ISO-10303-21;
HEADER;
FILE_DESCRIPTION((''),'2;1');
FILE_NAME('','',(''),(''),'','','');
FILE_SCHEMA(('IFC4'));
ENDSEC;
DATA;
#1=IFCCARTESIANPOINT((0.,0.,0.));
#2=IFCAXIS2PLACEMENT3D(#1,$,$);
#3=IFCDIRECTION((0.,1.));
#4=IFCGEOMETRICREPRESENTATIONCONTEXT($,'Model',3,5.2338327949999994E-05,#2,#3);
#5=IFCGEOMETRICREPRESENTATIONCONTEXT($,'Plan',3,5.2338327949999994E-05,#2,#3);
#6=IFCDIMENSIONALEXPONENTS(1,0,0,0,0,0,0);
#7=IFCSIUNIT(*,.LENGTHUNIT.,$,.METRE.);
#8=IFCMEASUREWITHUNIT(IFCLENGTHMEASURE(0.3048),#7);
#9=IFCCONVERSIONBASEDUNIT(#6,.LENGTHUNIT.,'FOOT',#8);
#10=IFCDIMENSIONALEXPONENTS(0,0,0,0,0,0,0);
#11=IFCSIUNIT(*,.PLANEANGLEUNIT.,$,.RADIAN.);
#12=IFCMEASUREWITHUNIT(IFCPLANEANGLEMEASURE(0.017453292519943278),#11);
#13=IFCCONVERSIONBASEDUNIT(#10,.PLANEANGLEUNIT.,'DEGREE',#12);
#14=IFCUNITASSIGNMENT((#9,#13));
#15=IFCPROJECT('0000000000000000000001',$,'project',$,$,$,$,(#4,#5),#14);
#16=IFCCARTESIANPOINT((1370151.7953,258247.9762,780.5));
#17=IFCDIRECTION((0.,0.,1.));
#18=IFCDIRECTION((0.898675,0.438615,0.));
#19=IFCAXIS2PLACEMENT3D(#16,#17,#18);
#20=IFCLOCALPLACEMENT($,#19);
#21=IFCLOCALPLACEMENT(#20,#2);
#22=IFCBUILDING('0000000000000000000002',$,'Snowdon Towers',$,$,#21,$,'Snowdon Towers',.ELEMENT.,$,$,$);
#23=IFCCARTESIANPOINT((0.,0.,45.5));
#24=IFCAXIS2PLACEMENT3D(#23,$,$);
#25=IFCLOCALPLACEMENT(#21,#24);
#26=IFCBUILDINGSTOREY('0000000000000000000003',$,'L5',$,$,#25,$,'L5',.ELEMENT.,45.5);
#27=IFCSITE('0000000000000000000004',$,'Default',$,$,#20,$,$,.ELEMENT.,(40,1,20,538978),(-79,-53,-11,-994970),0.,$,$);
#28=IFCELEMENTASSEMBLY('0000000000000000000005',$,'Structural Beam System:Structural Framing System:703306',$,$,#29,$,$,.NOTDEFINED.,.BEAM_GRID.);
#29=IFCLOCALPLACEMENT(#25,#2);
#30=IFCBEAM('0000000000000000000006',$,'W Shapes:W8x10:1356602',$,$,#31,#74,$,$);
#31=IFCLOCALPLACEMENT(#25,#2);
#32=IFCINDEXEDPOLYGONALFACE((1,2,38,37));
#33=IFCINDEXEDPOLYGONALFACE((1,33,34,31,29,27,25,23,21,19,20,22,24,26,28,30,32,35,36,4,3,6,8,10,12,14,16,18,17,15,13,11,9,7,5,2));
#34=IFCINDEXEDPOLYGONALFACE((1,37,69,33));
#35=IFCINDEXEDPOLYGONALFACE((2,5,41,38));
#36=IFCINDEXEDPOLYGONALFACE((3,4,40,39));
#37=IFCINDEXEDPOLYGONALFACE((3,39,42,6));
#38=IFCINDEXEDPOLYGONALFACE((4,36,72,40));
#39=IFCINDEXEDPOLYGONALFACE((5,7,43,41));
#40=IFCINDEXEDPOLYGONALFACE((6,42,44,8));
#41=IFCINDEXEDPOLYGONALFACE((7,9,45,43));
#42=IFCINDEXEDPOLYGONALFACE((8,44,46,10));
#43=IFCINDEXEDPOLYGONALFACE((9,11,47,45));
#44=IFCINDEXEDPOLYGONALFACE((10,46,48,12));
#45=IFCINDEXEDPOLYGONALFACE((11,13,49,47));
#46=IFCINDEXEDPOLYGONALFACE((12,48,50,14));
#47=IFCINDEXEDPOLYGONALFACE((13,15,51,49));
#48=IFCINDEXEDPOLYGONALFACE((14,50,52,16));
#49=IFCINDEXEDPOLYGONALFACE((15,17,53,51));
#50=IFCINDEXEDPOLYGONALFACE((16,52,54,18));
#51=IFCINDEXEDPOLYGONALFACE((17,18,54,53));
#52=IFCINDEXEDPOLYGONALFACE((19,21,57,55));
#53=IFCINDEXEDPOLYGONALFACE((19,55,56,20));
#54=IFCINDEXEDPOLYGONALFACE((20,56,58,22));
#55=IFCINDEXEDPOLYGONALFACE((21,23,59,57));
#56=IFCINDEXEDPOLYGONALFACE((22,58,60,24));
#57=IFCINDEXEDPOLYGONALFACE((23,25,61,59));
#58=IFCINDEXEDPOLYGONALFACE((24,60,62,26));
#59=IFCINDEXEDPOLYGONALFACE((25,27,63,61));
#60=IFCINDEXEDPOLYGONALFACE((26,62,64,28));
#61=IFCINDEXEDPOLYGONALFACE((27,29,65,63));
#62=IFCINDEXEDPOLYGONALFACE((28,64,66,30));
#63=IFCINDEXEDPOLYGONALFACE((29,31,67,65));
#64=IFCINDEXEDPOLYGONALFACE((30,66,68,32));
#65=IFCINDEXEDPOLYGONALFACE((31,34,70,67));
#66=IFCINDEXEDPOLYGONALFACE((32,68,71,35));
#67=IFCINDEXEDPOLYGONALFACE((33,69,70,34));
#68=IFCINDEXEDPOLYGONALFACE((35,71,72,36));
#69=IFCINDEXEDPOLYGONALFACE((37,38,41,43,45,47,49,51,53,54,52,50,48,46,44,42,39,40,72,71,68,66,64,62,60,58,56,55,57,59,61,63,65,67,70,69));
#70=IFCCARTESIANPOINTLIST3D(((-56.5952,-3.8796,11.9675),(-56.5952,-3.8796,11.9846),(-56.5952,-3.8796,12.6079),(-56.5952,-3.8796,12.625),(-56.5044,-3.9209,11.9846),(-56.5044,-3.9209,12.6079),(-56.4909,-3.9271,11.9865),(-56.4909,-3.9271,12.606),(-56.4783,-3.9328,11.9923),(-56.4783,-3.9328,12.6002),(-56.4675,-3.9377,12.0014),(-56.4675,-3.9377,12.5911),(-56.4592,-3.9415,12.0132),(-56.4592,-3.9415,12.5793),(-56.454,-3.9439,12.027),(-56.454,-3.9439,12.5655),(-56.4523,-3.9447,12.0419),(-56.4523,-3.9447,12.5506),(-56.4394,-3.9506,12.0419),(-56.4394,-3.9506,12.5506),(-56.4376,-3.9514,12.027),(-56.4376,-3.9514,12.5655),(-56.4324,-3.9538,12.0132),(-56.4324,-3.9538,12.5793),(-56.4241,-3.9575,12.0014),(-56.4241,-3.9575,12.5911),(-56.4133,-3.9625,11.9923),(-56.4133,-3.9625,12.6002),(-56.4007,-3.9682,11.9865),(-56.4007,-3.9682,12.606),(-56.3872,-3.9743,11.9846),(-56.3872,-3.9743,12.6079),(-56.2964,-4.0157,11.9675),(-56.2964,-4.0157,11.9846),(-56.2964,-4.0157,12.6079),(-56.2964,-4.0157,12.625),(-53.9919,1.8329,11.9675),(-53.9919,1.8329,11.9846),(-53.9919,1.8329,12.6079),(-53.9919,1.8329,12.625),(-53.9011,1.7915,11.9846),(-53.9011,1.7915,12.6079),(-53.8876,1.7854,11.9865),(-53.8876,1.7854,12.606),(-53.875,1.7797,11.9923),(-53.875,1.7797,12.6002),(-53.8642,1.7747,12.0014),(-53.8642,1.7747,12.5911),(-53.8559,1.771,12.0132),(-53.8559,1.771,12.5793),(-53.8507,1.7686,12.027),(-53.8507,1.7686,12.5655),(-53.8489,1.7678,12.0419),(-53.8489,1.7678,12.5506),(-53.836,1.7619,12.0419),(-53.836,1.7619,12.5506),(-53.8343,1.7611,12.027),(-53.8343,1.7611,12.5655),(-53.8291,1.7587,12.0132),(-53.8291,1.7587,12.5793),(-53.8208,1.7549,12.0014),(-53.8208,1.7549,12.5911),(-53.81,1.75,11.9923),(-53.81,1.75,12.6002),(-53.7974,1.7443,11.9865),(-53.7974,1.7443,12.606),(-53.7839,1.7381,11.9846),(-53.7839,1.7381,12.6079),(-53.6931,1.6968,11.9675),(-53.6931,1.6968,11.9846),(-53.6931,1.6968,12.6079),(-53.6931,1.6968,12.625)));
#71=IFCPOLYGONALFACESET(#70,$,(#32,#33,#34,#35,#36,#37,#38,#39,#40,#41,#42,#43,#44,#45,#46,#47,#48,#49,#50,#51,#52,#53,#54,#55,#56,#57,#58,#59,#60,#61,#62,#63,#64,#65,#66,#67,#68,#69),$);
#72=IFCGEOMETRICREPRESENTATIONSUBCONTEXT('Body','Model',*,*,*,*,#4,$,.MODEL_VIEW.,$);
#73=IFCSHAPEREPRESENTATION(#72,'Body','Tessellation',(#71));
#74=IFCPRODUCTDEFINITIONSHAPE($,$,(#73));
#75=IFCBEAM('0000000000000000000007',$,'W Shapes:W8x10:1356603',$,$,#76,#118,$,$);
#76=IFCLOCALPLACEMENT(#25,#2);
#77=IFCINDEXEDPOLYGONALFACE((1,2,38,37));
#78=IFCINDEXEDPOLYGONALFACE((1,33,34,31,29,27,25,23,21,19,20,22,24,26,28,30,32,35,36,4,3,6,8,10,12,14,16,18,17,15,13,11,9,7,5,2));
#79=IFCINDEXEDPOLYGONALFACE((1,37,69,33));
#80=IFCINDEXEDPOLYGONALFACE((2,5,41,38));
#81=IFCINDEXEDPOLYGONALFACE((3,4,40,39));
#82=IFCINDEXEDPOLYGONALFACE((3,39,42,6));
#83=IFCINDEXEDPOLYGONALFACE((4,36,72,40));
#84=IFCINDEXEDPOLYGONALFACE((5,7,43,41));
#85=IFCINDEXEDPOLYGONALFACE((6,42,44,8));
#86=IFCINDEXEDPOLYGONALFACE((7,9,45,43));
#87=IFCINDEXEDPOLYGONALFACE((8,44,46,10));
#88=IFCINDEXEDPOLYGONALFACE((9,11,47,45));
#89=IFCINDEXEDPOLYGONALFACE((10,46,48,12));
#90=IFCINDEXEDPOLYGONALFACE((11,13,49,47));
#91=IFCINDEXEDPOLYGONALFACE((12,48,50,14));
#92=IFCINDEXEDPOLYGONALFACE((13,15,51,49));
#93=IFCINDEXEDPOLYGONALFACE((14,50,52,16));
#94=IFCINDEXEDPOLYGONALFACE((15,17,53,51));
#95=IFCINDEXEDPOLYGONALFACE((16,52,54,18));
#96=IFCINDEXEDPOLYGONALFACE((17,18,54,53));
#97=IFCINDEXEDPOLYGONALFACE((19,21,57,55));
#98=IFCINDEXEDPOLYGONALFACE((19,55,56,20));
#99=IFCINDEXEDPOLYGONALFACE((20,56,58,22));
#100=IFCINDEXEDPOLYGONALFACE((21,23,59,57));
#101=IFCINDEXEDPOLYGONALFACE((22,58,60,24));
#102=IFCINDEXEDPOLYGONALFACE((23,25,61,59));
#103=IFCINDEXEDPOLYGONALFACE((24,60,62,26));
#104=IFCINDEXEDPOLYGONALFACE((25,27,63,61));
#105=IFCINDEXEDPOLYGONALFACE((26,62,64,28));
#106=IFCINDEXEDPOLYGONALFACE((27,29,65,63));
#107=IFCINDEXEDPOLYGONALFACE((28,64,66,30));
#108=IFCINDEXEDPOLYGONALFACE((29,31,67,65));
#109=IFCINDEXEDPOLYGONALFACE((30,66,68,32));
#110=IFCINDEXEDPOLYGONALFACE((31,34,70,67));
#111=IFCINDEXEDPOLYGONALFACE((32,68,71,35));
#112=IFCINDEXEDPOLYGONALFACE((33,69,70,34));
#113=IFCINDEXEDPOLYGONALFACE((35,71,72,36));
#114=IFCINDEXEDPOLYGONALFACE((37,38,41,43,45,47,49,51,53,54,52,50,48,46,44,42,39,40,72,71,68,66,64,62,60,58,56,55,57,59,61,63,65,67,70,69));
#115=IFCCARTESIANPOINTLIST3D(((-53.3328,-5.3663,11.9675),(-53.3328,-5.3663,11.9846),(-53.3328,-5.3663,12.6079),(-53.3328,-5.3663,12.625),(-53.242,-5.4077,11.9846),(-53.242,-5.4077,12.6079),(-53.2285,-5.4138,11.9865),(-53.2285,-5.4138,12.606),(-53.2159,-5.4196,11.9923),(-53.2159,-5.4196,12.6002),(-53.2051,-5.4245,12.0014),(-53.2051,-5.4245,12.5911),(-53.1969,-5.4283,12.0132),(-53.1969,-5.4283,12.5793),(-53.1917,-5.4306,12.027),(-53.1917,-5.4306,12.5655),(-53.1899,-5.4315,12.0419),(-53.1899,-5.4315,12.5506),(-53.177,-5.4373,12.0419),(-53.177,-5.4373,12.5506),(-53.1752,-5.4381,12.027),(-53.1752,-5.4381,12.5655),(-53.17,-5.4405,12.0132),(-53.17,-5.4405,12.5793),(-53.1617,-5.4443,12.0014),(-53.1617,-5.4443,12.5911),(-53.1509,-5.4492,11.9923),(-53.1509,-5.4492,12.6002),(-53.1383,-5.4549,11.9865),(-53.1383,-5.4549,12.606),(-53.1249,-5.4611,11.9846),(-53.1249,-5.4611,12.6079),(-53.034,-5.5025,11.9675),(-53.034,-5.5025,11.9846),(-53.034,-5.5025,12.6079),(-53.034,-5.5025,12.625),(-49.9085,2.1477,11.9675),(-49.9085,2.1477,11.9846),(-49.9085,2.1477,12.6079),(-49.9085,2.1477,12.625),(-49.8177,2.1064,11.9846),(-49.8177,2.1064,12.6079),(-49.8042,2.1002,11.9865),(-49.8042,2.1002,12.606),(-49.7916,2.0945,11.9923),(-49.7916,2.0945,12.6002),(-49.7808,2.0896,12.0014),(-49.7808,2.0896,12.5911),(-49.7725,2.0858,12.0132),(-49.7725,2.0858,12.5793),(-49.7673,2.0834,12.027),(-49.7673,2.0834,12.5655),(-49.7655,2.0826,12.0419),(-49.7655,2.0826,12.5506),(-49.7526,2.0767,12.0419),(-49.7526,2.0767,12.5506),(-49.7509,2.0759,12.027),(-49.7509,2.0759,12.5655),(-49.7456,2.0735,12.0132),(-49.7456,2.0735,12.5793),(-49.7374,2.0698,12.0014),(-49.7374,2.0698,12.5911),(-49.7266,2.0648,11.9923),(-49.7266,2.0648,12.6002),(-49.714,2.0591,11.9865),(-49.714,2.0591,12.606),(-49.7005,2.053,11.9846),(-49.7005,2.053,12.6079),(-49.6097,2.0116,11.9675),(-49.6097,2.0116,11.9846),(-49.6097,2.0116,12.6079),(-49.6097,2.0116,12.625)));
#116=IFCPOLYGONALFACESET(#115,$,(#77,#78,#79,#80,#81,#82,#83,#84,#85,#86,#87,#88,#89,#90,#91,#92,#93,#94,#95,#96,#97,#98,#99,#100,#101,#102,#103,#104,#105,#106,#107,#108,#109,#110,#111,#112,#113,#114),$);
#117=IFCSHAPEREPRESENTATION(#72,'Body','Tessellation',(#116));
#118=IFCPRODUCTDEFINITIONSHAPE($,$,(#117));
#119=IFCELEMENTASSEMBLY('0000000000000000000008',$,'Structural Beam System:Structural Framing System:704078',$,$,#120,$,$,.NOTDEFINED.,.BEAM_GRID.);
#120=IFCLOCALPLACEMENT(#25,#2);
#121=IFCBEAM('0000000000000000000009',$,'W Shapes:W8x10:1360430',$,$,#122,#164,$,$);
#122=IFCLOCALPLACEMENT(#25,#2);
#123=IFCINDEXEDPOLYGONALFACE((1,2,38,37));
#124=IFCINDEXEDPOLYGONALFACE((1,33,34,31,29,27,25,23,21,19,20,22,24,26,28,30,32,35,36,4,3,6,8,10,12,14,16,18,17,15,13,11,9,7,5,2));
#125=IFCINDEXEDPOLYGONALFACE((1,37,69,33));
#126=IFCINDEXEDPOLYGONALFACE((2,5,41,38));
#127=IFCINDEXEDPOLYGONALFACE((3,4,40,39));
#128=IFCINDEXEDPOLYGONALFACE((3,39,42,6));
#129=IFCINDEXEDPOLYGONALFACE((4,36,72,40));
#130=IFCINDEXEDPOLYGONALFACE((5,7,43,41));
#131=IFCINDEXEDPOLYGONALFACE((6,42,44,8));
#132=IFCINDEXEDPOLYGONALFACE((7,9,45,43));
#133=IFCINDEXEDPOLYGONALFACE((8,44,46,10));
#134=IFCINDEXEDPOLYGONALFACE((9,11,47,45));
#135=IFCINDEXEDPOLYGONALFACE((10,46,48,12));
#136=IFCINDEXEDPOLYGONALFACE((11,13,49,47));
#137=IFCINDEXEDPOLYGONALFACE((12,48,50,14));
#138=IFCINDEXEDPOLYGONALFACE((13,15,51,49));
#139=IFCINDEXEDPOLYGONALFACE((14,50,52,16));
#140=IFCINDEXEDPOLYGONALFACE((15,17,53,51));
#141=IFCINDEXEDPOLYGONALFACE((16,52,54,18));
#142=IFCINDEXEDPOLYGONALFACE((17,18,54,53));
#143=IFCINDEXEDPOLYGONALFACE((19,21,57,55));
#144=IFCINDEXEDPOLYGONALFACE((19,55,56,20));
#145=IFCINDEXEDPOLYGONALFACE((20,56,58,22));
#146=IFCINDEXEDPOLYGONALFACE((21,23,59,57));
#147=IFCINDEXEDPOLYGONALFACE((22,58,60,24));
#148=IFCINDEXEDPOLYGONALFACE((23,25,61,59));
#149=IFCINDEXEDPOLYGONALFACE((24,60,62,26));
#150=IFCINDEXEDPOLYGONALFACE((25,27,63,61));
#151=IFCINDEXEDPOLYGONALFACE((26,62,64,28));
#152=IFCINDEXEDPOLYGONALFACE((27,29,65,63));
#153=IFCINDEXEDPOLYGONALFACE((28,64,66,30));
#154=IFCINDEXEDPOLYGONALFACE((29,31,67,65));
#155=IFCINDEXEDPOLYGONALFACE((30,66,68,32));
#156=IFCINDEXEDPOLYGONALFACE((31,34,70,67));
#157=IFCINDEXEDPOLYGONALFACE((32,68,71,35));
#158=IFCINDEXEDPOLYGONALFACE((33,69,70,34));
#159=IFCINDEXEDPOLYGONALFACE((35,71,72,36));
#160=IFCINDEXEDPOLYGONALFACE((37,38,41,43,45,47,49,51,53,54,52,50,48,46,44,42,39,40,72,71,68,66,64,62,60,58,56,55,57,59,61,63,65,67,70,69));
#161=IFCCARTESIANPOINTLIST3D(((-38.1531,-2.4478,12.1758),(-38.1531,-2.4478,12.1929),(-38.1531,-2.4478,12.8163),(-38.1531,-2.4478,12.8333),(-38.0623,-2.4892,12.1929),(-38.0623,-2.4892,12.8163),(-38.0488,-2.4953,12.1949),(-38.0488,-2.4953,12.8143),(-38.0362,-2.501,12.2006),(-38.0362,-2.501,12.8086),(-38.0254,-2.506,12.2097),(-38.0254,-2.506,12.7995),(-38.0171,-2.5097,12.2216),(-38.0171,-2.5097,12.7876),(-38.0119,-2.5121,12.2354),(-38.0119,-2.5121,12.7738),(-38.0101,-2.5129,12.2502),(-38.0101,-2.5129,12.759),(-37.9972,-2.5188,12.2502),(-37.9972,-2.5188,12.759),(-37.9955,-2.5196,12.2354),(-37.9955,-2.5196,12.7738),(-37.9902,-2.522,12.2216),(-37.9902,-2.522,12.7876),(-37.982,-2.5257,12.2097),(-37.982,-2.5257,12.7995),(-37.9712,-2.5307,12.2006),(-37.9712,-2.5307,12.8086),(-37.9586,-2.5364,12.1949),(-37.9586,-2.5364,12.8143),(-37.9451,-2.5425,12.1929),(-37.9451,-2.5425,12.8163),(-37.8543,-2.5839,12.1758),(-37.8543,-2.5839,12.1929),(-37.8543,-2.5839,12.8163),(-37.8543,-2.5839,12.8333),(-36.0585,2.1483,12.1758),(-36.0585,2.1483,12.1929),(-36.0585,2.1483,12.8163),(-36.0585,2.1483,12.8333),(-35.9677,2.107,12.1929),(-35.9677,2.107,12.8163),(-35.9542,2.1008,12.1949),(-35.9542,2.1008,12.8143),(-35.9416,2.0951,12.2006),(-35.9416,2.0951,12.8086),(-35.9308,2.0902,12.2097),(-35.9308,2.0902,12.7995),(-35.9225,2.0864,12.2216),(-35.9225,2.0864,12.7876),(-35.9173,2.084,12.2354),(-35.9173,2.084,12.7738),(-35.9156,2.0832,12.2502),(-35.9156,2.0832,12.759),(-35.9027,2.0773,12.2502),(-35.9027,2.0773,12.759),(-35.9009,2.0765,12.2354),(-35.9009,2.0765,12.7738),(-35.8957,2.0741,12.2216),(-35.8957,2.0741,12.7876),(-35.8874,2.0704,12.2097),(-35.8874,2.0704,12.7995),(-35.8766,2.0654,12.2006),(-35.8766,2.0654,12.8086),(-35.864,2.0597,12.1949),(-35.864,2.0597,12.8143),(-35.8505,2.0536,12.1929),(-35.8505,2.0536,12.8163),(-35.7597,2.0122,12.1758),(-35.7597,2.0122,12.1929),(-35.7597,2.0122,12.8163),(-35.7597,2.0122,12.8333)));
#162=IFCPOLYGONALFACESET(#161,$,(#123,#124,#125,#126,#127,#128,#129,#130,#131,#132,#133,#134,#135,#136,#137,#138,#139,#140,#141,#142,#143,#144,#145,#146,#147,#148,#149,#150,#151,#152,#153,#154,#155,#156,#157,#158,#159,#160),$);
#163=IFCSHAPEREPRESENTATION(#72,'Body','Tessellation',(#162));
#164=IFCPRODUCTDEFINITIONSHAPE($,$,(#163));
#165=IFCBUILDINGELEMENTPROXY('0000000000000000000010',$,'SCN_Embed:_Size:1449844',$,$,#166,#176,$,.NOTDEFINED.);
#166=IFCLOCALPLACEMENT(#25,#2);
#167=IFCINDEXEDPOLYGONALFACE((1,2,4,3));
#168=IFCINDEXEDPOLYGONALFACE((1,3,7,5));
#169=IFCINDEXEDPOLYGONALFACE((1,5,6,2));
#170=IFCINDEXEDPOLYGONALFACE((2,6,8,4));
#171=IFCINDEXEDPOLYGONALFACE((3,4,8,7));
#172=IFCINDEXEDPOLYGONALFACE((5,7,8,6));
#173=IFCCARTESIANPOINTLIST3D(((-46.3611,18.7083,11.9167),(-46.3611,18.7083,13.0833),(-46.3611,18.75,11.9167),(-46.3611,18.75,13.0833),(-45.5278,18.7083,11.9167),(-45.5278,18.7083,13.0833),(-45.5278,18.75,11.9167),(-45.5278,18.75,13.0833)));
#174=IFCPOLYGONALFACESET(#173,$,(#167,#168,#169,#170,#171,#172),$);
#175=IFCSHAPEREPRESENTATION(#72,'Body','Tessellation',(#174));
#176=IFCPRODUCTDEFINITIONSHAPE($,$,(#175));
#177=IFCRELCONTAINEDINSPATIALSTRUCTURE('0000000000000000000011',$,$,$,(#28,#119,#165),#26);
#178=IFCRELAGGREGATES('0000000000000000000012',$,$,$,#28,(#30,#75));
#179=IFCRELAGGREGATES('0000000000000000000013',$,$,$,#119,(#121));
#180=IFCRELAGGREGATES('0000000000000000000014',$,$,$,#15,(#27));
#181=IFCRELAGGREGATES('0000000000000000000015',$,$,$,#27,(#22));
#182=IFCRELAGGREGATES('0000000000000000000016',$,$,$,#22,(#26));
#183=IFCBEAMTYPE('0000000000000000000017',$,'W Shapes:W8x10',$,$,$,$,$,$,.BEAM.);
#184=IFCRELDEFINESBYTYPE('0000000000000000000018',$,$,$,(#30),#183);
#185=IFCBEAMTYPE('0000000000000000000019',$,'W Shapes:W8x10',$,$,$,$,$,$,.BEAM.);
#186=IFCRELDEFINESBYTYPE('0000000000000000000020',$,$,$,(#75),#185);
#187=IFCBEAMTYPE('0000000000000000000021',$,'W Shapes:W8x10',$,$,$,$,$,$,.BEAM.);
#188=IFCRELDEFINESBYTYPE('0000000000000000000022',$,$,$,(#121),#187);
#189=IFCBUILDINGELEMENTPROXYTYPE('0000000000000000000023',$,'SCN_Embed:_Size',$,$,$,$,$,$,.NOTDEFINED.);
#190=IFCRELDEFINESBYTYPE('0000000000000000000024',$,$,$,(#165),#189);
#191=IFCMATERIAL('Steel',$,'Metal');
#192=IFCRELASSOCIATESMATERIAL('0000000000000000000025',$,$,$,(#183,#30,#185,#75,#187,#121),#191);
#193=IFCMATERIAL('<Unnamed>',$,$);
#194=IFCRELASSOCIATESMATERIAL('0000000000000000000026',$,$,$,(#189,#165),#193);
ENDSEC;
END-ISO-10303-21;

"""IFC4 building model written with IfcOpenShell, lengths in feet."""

from ifc_helpers import new_model, entity, si_unit, converted_unit, direction, frame, origin, place, context, subcontext, project, spatial, line, arc, indexed_curve, outline, extrude, source, transform, mapped, material, type_object, type_shapes, element, aggregate, save


model = new_model("IFC4")

# Units and contexts
model_context = context("Model", 3, precision=5.2338327949999994e-05, world=origin(), true_north=direction((0.0, 1.0)))
plan_context = context("Plan", 3, precision=5.2338327949999994e-05, world=origin(), true_north=direction((0.0, 1.0)))
body_context = subcontext(model_context, "Body", "Model", "MODEL_VIEW")
ifc_project = project(units=[converted_unit("LENGTHUNIT", "FOOT", entity("IfcLengthMeasure", 0.3048), si_unit("LENGTHUNIT", "METRE"), dimensions=[1, 0, 0, 0, 0, 0, 0]), converted_unit("PLANEANGLEUNIT", "DEGREE", entity("IfcPlaneAngleMeasure", 0.017453292519943278), si_unit("PLANEANGLEUNIT", "RADIAN"), dimensions=[0, 0, 0, 0, 0, 0, 0])], contexts=[model_context, plan_context])

# Site, building, storey
site_placement = place(None, frame((1370151.7953, 258247.9762, 780.5), z_axis=(0.0, 0.0, 1.0), x_axis=(0.898675, 0.438615, 0.0)))
site = spatial("IfcSite", under=ifc_project, at=site_placement, Name="Default", CompositionType="ELEMENT", RefLatitude=(40, 1, 20, 538978), RefLongitude=(-79, -53, -11, -994970), RefElevation=0.0)
building_placement = place(site_placement, origin())
building = spatial("IfcBuilding", under=site, at=building_placement, Name="Snowdon Towers", LongName="Snowdon Towers", CompositionType="ELEMENT")
storey_placement = place(building_placement, frame((0.0, 0.0, 45.5)))
storey = spatial("IfcBuildingStorey", under=building, at=storey_placement, Name="L5", LongName="L5", CompositionType="ELEMENT", Elevation=45.5)

# Shared definitions
ifc_material_1 = material(Name="Steel", Category="Metal")

# Element assembly, beams
assembly_1_placement = place(storey_placement, origin())
assembly_1 = element("IfcElementAssembly", 1, at=assembly_1_placement, inside=storey, Name="Structural Beam System:Structural Framing System:703306", AssemblyPlace="NOTDEFINED", PredefinedType="BEAM_GRID")
beam_type_1 = type_object("IfcBeamType", Name="W Shapes:W8x10", PredefinedType="BEAM", material=ifc_material_1)
shared_shape_1 = source(origin(), body_context, "Body", "SweptSolid", [
    extrude(outline(indexed_curve([(-0.3287, -0.1642), (-0.3117, -0.1642), (-0.3117, -0.0644), (-0.2949, -0.0239), (-0.2544, -0.0071), (0.2544, -0.0071), (0.2949, -0.0239), (0.3117, -0.0644), (0.3117, -0.1642), (0.3288, -0.1642), (0.3288, 0.1642), (0.3117, 0.1642), (0.3117, 0.0644), (0.2949, 0.0239), (0.2544, 0.0071), (-0.2544, 0.0071), (-0.2949, 0.0239), (-0.3117, 0.0644), (-0.3117, 0.1642), (-0.3287, 0.1642)], segments=[line(1, 2, 3), arc(3, 4, 5), line(5, 6), arc(6, 7, 8), line(8, 9, 10, 11, 12, 13), arc(13, 14, 15), line(15, 16), arc(16, 17, 18), line(18, 19, 20, 1)], self_intersect=False)), frame((-3.3868, 0.0, 0.0), z_axis=(1.0, 0.0, 0.0), x_axis=(0.0, 0.0, -1.0)), (0.0, 0.0, 1.0), 6.2777),
])
type_shapes(beam_type_1, [shared_shape_1])
beam_1_placement = place(assembly_1_placement, frame((-55.0413, -0.8658, 12.2963), z_axis=(0.0, 0.0, 1.0), x_axis=(0.414693, 0.909961, 0.0)))
beam_1 = element("IfcBeam", 2, at=beam_1_placement, type_object=beam_type_1, material=ifc_material_1, Name="W Shapes:W8x10:1356602", context=body_context, shape_type="MappedRepresentation", body=[
    mapped(shared_shape_1, transform((0.0, 0.0, 0.0), scale=1.0)),
])
beam_type_2 = type_object("IfcBeamType", Name="W Shapes:W8x10", PredefinedType="BEAM", material=ifc_material_1)
shared_shape_2 = source(origin(), body_context, "Body", "SweptSolid", [
    extrude(outline(indexed_curve([(-0.3287, -0.1642), (-0.3117, -0.1642), (-0.3117, -0.0644), (-0.2949, -0.0239), (-0.2544, -0.0071), (0.2544, -0.0071), (0.2949, -0.0239), (0.3117, -0.0644), (0.3117, -0.1642), (0.3288, -0.1642), (0.3288, 0.1642), (0.3117, 0.1642), (0.3117, 0.0644), (0.2949, 0.0239), (0.2544, 0.0071), (-0.2544, 0.0071), (-0.2949, 0.0239), (-0.3117, 0.0644), (-0.3117, 0.1642), (-0.3287, 0.1642)], segments=[line(1, 2, 3), arc(3, 4, 5), line(5, 6), arc(6, 7, 8), line(8, 9, 10, 11, 12, 13), arc(13, 14, 15), line(15, 16), arc(16, 17, 18), line(18, 19, 20, 1)], self_intersect=False)), frame((-4.2037, 0.0, 0.0), z_axis=(1.0, 0.0, 0.0), x_axis=(0.0, 0.0, -1.0)), (0.0, 0.0, 1.0), 8.2576),
])
type_shapes(beam_type_2, [shared_shape_2])
beam_2_placement = place(assembly_1_placement, frame((-51.4402, -1.6092, 12.2963), z_axis=(0.0, 0.0, 1.0), x_axis=(0.414693, 0.909961, 0.0)))
beam_2 = element("IfcBeam", 3, at=beam_2_placement, type_object=beam_type_2, material=ifc_material_1, Name="W Shapes:W8x10:1356603", context=body_context, shape_type="MappedRepresentation", body=[
    mapped(shared_shape_2, transform((0.0, 0.0, 0.0), scale=1.0)),
])
aggregate(assembly_1, [beam_1, beam_2])

# Element assembly, beam
assembly_2_placement = place(storey_placement, origin())
assembly_2 = element("IfcElementAssembly", 4, at=assembly_2_placement, inside=storey, Name="Structural Beam System:Structural Framing System:704078", AssemblyPlace="NOTDEFINED", PredefinedType="BEAM_GRID")
beam_type_3 = type_object("IfcBeamType", Name="W Shapes:W8x10", PredefinedType="BEAM", material=ifc_material_1)
shared_shape_3 = source(origin(), body_context, "Body", "SweptSolid", [
    extrude(outline(indexed_curve([(-0.3287, -0.1642), (-0.3117, -0.1642), (-0.3117, -0.0644), (-0.2949, -0.0239), (-0.2544, -0.0071), (0.2544, -0.0071), (0.2949, -0.0239), (0.3117, -0.0644), (0.3117, -0.1642), (0.3288, -0.1642), (0.3288, 0.1642), (0.3117, 0.1642), (0.3117, 0.0644), (0.2949, 0.0239), (0.2544, 0.0071), (-0.2544, 0.0071), (-0.2949, 0.0239), (-0.3117, 0.0644), (-0.3117, 0.1642), (-0.3287, 0.1642)], segments=[line(1, 2, 3), arc(3, 4, 5), line(5, 6), arc(6, 7, 8), line(8, 9, 10, 11, 12, 13), arc(13, 14, 15), line(15, 16), arc(16, 17, 18), line(18, 19, 20, 1)], self_intersect=False)), frame((-2.6, 0.0, 0.0), z_axis=(1.0, 0.0, 0.0), x_axis=(0.0, 0.0, -1.0)), (0.0, 0.0, 1.0), 5.0509),
])
type_shapes(beam_type_3, [shared_shape_3])
beam_3_placement = place(assembly_2_placement, frame((-36.9255, -0.1499, 12.5046), z_axis=(0.0, 0.0, 1.0), x_axis=(0.414693, 0.909961, 0.0)))
beam_3 = element("IfcBeam", 5, at=beam_3_placement, type_object=beam_type_3, material=ifc_material_1, Name="W Shapes:W8x10:1360430", context=body_context, shape_type="MappedRepresentation", body=[
    mapped(shared_shape_3, transform((0.0, 0.0, 0.0), scale=1.0)),
])
aggregate(assembly_2, [beam_3])

# Building element proxy
ifc_material_2 = material(Name="<Unnamed>")
building_element_proxy_type_1 = type_object("IfcBuildingElementProxyType", Name="SCN_Embed:_Size", PredefinedType="NOTDEFINED", material=ifc_material_2)
shared_shape_4 = source(origin(), body_context, "Body", "SweptSolid", [
    extrude(outline(indexed_curve([(-0.4167, -0.5833), (0.4167, -0.5833), (0.4167, 0.5833), (-0.4167, 0.5833), (-0.4167, -0.5833)], self_intersect=False)), frame((0.0, 0.0, -0.0417), z_axis=(0.0, 0.0, 1.0), x_axis=(-1.0, 0.0, 0.0)), (0.0, 0.0, 1.0), 0.0417),
])
type_shapes(building_element_proxy_type_1, [shared_shape_4])
proxy_placement = place(storey_placement, frame((-45.9444, 18.7083, 12.5), z_axis=(0.0, -1.0, 0.0), x_axis=(1.0, 0.0, 0.0)))
element("IfcBuildingElementProxy", 6, at=proxy_placement, inside=storey, type_object=building_element_proxy_type_1, material=ifc_material_2, Name="SCN_Embed:_Size:1449844", PredefinedType="NOTDEFINED", context=body_context, shape_type="MappedRepresentation", body=[
    mapped(shared_shape_4, transform((0.0, 0.0, 0.0), scale=1.0)),
])

save(model, "model.ifc")
